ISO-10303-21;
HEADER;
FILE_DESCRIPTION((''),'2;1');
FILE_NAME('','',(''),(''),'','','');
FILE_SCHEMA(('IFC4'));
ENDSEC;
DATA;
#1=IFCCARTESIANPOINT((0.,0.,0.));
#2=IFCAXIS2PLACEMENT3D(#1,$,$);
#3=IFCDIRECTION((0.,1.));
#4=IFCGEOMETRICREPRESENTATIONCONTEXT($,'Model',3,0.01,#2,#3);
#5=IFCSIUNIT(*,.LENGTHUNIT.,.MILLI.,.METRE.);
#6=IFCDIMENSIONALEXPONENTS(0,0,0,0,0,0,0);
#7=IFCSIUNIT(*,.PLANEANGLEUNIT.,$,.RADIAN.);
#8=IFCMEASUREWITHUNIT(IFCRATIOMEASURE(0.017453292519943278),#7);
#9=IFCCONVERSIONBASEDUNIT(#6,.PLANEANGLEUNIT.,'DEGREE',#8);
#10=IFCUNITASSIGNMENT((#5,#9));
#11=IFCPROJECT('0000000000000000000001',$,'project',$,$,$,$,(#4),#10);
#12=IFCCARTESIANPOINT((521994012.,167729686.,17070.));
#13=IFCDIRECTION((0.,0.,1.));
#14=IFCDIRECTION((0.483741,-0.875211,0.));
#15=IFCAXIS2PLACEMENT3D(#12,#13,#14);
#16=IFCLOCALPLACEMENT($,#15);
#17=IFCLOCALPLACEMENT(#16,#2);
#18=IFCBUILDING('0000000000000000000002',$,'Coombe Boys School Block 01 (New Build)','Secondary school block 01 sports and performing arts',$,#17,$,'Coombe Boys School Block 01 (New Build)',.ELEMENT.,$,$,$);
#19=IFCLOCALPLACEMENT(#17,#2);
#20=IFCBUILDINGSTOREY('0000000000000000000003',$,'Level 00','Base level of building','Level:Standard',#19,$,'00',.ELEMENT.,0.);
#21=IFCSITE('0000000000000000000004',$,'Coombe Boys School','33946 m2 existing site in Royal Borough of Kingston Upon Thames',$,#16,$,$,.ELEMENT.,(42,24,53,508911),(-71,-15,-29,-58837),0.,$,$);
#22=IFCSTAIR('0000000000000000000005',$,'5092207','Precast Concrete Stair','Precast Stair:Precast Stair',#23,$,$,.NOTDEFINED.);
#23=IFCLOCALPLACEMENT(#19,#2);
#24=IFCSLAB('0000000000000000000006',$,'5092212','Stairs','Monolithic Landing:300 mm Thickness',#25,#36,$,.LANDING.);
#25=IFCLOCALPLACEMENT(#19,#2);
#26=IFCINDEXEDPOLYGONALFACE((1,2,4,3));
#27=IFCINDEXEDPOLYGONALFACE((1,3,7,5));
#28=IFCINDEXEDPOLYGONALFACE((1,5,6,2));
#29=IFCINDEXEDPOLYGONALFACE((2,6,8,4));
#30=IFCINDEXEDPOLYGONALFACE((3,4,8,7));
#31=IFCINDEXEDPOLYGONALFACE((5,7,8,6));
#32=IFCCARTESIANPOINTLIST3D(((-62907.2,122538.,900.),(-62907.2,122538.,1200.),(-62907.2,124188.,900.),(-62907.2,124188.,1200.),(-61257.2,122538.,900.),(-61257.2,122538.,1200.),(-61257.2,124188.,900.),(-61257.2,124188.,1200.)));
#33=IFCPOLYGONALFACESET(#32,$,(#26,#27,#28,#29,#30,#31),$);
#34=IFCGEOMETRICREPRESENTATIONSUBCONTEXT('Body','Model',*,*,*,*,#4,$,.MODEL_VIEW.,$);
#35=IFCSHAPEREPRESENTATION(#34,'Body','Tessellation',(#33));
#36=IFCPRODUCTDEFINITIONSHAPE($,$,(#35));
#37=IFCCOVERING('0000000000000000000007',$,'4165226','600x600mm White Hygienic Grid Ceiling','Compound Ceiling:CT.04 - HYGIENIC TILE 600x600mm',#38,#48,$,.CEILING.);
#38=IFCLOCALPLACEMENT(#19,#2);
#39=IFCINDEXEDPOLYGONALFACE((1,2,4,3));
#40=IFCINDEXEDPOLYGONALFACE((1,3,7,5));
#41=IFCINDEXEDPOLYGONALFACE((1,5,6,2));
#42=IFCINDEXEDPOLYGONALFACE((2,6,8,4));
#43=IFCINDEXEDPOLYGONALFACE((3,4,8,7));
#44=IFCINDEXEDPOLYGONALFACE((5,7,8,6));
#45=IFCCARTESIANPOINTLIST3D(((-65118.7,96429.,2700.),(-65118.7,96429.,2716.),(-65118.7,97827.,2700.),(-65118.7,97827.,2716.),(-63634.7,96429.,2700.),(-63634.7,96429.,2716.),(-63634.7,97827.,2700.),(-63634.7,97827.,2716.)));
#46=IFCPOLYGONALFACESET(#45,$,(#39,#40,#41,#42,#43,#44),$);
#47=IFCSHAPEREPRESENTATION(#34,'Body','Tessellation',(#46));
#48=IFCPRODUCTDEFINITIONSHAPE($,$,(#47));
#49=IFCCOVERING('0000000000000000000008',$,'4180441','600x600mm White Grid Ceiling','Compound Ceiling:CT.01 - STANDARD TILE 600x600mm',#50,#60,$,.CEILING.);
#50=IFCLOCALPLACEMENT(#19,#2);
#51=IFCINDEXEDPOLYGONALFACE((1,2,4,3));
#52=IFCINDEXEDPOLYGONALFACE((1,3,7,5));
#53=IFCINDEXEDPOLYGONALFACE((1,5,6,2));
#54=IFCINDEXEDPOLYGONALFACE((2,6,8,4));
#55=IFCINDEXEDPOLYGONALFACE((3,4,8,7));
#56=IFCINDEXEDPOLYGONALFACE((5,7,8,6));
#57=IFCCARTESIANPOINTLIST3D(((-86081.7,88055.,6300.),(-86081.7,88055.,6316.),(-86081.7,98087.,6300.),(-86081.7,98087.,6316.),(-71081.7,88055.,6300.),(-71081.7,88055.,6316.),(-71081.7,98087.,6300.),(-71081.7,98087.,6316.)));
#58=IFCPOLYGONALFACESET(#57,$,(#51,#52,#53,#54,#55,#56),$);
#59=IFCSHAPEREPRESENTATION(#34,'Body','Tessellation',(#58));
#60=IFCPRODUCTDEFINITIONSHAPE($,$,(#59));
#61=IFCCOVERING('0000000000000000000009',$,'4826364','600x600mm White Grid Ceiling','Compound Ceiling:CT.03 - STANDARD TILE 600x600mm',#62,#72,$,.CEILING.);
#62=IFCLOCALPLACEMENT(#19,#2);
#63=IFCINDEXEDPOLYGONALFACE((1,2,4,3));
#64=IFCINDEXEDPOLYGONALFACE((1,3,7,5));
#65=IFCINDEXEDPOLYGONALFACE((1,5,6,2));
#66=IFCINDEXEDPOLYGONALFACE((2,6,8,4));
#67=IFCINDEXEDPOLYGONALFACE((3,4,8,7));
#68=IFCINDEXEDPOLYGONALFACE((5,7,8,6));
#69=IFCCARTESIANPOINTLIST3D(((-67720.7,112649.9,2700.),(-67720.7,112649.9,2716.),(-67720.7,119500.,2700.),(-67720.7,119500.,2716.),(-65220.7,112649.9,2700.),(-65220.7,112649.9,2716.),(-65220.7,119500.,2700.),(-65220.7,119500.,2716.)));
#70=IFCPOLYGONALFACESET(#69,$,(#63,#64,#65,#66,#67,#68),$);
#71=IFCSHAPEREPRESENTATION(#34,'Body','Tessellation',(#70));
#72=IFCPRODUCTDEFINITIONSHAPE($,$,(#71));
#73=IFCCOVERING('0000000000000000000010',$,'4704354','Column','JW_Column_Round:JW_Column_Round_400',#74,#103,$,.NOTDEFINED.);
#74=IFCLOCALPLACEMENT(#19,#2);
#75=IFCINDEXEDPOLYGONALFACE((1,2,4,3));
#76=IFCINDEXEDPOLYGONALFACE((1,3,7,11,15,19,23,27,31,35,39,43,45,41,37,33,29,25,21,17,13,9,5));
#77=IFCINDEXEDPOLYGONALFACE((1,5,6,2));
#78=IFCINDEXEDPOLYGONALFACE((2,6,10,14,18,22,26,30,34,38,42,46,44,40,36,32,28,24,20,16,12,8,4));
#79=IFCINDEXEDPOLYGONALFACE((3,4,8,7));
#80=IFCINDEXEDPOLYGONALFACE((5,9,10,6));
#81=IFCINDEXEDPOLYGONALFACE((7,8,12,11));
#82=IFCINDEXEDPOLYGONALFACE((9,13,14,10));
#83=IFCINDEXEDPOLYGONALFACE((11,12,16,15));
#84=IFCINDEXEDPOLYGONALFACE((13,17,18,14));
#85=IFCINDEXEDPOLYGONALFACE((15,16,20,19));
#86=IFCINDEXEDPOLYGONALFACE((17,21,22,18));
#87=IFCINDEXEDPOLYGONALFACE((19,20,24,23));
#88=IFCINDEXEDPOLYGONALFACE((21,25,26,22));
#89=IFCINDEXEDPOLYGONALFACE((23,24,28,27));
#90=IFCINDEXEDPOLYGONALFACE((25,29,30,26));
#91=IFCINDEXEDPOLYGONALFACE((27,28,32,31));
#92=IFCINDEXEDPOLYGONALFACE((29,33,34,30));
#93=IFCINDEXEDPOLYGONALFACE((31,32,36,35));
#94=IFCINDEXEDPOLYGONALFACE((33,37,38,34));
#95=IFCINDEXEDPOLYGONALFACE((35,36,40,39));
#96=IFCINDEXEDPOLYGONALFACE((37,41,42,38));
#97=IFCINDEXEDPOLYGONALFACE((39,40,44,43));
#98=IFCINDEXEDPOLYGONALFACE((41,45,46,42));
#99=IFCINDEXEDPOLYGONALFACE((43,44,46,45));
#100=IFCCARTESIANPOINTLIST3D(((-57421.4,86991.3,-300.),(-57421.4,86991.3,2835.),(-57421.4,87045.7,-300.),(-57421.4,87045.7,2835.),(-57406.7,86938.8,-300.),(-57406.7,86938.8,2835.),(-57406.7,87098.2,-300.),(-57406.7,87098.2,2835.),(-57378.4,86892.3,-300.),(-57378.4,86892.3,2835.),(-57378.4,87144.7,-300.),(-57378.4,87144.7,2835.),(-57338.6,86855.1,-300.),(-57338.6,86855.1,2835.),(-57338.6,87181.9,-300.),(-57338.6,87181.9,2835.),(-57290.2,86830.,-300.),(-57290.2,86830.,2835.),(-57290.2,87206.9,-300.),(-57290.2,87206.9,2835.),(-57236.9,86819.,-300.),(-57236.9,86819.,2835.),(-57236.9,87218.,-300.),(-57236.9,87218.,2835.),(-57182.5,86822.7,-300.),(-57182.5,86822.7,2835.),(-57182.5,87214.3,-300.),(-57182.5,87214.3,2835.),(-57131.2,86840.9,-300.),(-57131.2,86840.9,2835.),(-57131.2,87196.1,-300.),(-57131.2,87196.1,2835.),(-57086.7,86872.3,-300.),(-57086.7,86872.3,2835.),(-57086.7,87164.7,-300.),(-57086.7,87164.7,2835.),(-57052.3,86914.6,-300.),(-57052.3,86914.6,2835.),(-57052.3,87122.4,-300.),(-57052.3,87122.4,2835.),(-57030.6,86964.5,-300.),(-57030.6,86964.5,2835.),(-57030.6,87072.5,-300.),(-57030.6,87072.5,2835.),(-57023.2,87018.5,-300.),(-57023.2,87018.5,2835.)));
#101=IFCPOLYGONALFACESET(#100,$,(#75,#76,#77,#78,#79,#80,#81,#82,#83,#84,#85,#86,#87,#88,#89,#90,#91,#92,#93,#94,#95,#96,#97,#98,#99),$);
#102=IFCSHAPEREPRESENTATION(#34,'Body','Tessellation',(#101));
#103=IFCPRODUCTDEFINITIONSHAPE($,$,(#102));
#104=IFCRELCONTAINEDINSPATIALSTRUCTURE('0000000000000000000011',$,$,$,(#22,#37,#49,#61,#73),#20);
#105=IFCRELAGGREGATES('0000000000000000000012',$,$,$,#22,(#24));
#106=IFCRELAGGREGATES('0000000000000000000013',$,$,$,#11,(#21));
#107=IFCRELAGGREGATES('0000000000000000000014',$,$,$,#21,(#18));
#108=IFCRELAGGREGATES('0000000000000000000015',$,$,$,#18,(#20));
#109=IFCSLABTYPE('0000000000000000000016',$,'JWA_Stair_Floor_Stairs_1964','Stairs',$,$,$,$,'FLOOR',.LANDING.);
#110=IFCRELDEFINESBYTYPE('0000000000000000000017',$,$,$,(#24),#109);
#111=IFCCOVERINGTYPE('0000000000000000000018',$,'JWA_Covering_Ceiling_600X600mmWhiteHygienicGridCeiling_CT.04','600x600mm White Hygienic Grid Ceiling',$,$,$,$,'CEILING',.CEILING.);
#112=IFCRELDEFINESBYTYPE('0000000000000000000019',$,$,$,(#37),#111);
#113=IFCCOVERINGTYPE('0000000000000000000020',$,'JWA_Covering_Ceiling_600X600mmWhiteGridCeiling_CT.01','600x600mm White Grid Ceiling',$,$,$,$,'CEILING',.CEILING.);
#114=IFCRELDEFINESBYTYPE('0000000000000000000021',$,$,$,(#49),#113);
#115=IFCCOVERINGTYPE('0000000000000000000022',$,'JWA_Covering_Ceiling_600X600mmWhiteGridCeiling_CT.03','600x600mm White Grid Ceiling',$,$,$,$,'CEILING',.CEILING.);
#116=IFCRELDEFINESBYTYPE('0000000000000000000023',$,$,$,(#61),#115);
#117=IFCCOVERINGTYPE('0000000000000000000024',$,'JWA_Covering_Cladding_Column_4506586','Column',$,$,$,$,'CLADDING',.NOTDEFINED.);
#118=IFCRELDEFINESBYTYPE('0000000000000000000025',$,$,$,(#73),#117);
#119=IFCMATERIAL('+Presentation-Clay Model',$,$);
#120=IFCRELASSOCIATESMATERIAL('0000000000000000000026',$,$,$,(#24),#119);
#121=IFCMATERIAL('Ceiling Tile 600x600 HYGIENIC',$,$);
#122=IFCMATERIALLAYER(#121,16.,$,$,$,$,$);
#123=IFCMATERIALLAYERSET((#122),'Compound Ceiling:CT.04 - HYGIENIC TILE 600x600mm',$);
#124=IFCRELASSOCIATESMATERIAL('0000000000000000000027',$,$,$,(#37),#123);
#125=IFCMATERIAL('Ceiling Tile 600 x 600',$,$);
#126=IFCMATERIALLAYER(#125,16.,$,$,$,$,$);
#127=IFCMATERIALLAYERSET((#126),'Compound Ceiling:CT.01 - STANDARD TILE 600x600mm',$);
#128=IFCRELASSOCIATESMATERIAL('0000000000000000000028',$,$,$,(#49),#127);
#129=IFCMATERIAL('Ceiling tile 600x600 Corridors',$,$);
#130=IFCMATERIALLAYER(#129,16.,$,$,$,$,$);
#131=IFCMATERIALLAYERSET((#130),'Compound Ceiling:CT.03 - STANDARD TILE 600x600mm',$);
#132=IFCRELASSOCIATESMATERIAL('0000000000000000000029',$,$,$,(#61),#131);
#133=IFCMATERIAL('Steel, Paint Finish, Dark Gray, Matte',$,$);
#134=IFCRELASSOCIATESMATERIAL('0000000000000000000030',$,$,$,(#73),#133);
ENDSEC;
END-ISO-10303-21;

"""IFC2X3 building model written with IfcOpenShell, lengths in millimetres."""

from ifc_helpers import new_model, entity, si_unit, converted_unit, direction, frame, frame_2d, origin, origin_2d_with_axis, place, context, subcontext, project, spatial, rectangle, circle, extrude, material, layer, layer_set, layer_usage, type_object, element, aggregate, save


model = new_model("IFC2X3")

# Units and contexts
model_context = context("Model", 3, precision=0.01, world=origin(), true_north=direction((0.0, 1.0)))
body_context = subcontext(model_context, "Body", "Model", "MODEL_VIEW")
ifc_project = project(units=[si_unit("LENGTHUNIT", "METRE", prefix="MILLI"), converted_unit("PLANEANGLEUNIT", "DEGREE", entity("IfcRatioMeasure", 0.017453292519943278), si_unit("PLANEANGLEUNIT", "RADIAN"), dimensions=[0, 0, 0, 0, 0, 0, 0])], contexts=[model_context])

# Site, building, storey
site_placement = place(None, frame((521994012.0, 167729686.0, 17070.0), z_axis=(0.0, 0.0, 1.0), x_axis=(0.483741, -0.875211, 0.0)))
site = spatial("IfcSite", under=ifc_project, at=site_placement, Name="Coombe Boys School", Description="33946 m2 existing site in Royal Borough of Kingston Upon Thames", CompositionType="ELEMENT", RefLatitude=(42, 24, 53, 508911), RefLongitude=(-71, -15, -29, -58837), RefElevation=0.0)
building_placement = place(site_placement, origin())
building = spatial("IfcBuilding", under=site, at=building_placement, Name="Coombe Boys School Block 01 (New Build)", Description="Secondary school block 01 sports and performing arts", LongName="Coombe Boys School Block 01 (New Build)", CompositionType="ELEMENT")
storey_placement = place(building_placement, origin())
storey = spatial("IfcBuildingStorey", under=building, at=storey_placement, Name="Level 00", Description="Base level of building", ObjectType="Level:Standard", LongName="00", CompositionType="ELEMENT", Elevation=0.0)

# Shared definitions
ifc_material_1 = material(Name="+Presentation-Clay Model")
slab_type_1 = type_object("IfcSlabType", Name="JWA_Stair_Floor_Stairs_1964", Description="Stairs", ElementType="FLOOR", PredefinedType="LANDING")

# Stair, slab
stair_1_placement = place(storey_placement, origin())
stair_1 = element("IfcStair", 1, at=stair_1_placement, inside=storey, Name="5092207", Description="Precast Concrete Stair", ObjectType="Precast Stair:Precast Stair", ShapeType="NOTDEFINED")
slab_1_placement = place(stair_1_placement, origin())
slab_1 = element("IfcSlab", 2, at=slab_1_placement, type_object=slab_type_1, material=ifc_material_1, Name="5092212", Description="Stairs", ObjectType="Monolithic Landing:300 mm Thickness", PredefinedType="LANDING", context=body_context, shape_type="SweptSolid", body=[
    extrude(rectangle(XDim=1650.0, YDim=1650.0, at=frame_2d((0.0, 0.0), x_axis=(1.0, 0.0))), frame((-62082.2, 123363.0, 900.0)), (0.0, 0.0, 1.0), 300.0),
])
aggregate(stair_1, [slab_1])

# Coverings
ifc_material_2 = material(Name="Ceiling Tile 600x600 HYGIENIC")
ifc_layer_1 = layer(ifc_material_2, 16.0)
ifc_layer_set_1 = layer_set([ifc_layer_1], Name="Compound Ceiling:CT.04 - HYGIENIC TILE 600x600mm")
ifc_layer_usage_1 = layer_usage(ifc_layer_set_1, "AXIS3", "POSITIVE", 0.0)
covering_type_1 = type_object("IfcCoveringType", Name="JWA_Covering_Ceiling_600X600mmWhiteHygienicGridCeiling_CT.04", Description="600x600mm White Hygienic Grid Ceiling", ElementType="CEILING", PredefinedType="CEILING")
covering_1_placement = place(storey_placement, origin())
element("IfcCovering", 3, at=covering_1_placement, inside=storey, type_object=covering_type_1, material=ifc_layer_usage_1, Name="4165226", Description="600x600mm White Hygienic Grid Ceiling", ObjectType="Compound Ceiling:CT.04 - HYGIENIC TILE 600x600mm", PredefinedType="CEILING", context=body_context, shape_type="SweptSolid", body=[
    extrude(rectangle(XDim=1484.0, YDim=1398.0, at=frame_2d((0.0, 0.0), x_axis=(1.0, 0.0))), frame((-64376.7, 97128.0, 2700.0), z_axis=(0.0, 0.0, 1.0), x_axis=(-1.0, 0.0, 0.0)), (0.0, 0.0, 1.0), 16.0),
])
ifc_material_3 = material(Name="Ceiling Tile 600 x 600")
ifc_layer_2 = layer(ifc_material_3, 16.0)
ifc_layer_set_2 = layer_set([ifc_layer_2], Name="Compound Ceiling:CT.01 - STANDARD TILE 600x600mm")
ifc_layer_usage_2 = layer_usage(ifc_layer_set_2, "AXIS3", "POSITIVE", 0.0)
covering_type_2 = type_object("IfcCoveringType", Name="JWA_Covering_Ceiling_600X600mmWhiteGridCeiling_CT.01", Description="600x600mm White Grid Ceiling", ElementType="CEILING", PredefinedType="CEILING")
covering_2_placement = place(storey_placement, origin())
element("IfcCovering", 4, at=covering_2_placement, inside=storey, type_object=covering_type_2, material=ifc_layer_usage_2, Name="4180441", Description="600x600mm White Grid Ceiling", ObjectType="Compound Ceiling:CT.01 - STANDARD TILE 600x600mm", PredefinedType="CEILING", context=body_context, shape_type="SweptSolid", body=[
    extrude(rectangle(XDim=10032.0, YDim=15000.0, at=frame_2d((0.0, 0.0), x_axis=(1.0, 0.0))), frame((-78581.7, 93071.0, 6300.0), z_axis=(0.0, 0.0, 1.0), x_axis=(0.0, 1.0, 0.0)), (0.0, 0.0, 1.0), 16.0),
])
ifc_material_4 = material(Name="Ceiling tile 600x600 Corridors")
ifc_layer_3 = layer(ifc_material_4, 16.0)
ifc_layer_set_3 = layer_set([ifc_layer_3], Name="Compound Ceiling:CT.03 - STANDARD TILE 600x600mm")
ifc_layer_usage_3 = layer_usage(ifc_layer_set_3, "AXIS3", "POSITIVE", 0.0)
covering_type_3 = type_object("IfcCoveringType", Name="JWA_Covering_Ceiling_600X600mmWhiteGridCeiling_CT.03", Description="600x600mm White Grid Ceiling", ElementType="CEILING", PredefinedType="CEILING")
covering_3_placement = place(storey_placement, origin())
element("IfcCovering", 5, at=covering_3_placement, inside=storey, type_object=covering_type_3, material=ifc_layer_usage_3, Name="4826364", Description="600x600mm White Grid Ceiling", ObjectType="Compound Ceiling:CT.03 - STANDARD TILE 600x600mm", PredefinedType="CEILING", context=body_context, shape_type="SweptSolid", body=[
    extrude(rectangle(XDim=2500.0, YDim=6850.1, at=frame_2d((0.0, 0.0), x_axis=(1.0, 0.0))), frame((-66470.7, 116074.9, 2700.0), z_axis=(0.0, 0.0, 1.0), x_axis=(-1.0, 0.0, 0.0)), (0.0, 0.0, 1.0), 16.0),
])
ifc_material_5 = material(Name="Steel, Paint Finish, Dark Gray, Matte")
covering_type_4 = type_object("IfcCoveringType", Name="JWA_Covering_Cladding_Column_4506586", Description="Column", ElementType="CLADDING", PredefinedType="NOTDEFINED")
covering_4_placement = place(storey_placement, origin())
element("IfcCovering", 6, at=covering_4_placement, inside=storey, type_object=covering_type_4, material=ifc_material_5, Name="4704354", Description="Column", ObjectType="JW_Column_Round:JW_Column_Round_400", PredefinedType="NOTDEFINED", context=body_context, shape_type="SweptSolid", body=[
    extrude(circle(Radius=200.0, at=origin_2d_with_axis()), frame((-57223.2, 87018.5, -300.0)), (0.0, 0.0, 1.0), 3135.0),
])

save(model, "model.ifc")
